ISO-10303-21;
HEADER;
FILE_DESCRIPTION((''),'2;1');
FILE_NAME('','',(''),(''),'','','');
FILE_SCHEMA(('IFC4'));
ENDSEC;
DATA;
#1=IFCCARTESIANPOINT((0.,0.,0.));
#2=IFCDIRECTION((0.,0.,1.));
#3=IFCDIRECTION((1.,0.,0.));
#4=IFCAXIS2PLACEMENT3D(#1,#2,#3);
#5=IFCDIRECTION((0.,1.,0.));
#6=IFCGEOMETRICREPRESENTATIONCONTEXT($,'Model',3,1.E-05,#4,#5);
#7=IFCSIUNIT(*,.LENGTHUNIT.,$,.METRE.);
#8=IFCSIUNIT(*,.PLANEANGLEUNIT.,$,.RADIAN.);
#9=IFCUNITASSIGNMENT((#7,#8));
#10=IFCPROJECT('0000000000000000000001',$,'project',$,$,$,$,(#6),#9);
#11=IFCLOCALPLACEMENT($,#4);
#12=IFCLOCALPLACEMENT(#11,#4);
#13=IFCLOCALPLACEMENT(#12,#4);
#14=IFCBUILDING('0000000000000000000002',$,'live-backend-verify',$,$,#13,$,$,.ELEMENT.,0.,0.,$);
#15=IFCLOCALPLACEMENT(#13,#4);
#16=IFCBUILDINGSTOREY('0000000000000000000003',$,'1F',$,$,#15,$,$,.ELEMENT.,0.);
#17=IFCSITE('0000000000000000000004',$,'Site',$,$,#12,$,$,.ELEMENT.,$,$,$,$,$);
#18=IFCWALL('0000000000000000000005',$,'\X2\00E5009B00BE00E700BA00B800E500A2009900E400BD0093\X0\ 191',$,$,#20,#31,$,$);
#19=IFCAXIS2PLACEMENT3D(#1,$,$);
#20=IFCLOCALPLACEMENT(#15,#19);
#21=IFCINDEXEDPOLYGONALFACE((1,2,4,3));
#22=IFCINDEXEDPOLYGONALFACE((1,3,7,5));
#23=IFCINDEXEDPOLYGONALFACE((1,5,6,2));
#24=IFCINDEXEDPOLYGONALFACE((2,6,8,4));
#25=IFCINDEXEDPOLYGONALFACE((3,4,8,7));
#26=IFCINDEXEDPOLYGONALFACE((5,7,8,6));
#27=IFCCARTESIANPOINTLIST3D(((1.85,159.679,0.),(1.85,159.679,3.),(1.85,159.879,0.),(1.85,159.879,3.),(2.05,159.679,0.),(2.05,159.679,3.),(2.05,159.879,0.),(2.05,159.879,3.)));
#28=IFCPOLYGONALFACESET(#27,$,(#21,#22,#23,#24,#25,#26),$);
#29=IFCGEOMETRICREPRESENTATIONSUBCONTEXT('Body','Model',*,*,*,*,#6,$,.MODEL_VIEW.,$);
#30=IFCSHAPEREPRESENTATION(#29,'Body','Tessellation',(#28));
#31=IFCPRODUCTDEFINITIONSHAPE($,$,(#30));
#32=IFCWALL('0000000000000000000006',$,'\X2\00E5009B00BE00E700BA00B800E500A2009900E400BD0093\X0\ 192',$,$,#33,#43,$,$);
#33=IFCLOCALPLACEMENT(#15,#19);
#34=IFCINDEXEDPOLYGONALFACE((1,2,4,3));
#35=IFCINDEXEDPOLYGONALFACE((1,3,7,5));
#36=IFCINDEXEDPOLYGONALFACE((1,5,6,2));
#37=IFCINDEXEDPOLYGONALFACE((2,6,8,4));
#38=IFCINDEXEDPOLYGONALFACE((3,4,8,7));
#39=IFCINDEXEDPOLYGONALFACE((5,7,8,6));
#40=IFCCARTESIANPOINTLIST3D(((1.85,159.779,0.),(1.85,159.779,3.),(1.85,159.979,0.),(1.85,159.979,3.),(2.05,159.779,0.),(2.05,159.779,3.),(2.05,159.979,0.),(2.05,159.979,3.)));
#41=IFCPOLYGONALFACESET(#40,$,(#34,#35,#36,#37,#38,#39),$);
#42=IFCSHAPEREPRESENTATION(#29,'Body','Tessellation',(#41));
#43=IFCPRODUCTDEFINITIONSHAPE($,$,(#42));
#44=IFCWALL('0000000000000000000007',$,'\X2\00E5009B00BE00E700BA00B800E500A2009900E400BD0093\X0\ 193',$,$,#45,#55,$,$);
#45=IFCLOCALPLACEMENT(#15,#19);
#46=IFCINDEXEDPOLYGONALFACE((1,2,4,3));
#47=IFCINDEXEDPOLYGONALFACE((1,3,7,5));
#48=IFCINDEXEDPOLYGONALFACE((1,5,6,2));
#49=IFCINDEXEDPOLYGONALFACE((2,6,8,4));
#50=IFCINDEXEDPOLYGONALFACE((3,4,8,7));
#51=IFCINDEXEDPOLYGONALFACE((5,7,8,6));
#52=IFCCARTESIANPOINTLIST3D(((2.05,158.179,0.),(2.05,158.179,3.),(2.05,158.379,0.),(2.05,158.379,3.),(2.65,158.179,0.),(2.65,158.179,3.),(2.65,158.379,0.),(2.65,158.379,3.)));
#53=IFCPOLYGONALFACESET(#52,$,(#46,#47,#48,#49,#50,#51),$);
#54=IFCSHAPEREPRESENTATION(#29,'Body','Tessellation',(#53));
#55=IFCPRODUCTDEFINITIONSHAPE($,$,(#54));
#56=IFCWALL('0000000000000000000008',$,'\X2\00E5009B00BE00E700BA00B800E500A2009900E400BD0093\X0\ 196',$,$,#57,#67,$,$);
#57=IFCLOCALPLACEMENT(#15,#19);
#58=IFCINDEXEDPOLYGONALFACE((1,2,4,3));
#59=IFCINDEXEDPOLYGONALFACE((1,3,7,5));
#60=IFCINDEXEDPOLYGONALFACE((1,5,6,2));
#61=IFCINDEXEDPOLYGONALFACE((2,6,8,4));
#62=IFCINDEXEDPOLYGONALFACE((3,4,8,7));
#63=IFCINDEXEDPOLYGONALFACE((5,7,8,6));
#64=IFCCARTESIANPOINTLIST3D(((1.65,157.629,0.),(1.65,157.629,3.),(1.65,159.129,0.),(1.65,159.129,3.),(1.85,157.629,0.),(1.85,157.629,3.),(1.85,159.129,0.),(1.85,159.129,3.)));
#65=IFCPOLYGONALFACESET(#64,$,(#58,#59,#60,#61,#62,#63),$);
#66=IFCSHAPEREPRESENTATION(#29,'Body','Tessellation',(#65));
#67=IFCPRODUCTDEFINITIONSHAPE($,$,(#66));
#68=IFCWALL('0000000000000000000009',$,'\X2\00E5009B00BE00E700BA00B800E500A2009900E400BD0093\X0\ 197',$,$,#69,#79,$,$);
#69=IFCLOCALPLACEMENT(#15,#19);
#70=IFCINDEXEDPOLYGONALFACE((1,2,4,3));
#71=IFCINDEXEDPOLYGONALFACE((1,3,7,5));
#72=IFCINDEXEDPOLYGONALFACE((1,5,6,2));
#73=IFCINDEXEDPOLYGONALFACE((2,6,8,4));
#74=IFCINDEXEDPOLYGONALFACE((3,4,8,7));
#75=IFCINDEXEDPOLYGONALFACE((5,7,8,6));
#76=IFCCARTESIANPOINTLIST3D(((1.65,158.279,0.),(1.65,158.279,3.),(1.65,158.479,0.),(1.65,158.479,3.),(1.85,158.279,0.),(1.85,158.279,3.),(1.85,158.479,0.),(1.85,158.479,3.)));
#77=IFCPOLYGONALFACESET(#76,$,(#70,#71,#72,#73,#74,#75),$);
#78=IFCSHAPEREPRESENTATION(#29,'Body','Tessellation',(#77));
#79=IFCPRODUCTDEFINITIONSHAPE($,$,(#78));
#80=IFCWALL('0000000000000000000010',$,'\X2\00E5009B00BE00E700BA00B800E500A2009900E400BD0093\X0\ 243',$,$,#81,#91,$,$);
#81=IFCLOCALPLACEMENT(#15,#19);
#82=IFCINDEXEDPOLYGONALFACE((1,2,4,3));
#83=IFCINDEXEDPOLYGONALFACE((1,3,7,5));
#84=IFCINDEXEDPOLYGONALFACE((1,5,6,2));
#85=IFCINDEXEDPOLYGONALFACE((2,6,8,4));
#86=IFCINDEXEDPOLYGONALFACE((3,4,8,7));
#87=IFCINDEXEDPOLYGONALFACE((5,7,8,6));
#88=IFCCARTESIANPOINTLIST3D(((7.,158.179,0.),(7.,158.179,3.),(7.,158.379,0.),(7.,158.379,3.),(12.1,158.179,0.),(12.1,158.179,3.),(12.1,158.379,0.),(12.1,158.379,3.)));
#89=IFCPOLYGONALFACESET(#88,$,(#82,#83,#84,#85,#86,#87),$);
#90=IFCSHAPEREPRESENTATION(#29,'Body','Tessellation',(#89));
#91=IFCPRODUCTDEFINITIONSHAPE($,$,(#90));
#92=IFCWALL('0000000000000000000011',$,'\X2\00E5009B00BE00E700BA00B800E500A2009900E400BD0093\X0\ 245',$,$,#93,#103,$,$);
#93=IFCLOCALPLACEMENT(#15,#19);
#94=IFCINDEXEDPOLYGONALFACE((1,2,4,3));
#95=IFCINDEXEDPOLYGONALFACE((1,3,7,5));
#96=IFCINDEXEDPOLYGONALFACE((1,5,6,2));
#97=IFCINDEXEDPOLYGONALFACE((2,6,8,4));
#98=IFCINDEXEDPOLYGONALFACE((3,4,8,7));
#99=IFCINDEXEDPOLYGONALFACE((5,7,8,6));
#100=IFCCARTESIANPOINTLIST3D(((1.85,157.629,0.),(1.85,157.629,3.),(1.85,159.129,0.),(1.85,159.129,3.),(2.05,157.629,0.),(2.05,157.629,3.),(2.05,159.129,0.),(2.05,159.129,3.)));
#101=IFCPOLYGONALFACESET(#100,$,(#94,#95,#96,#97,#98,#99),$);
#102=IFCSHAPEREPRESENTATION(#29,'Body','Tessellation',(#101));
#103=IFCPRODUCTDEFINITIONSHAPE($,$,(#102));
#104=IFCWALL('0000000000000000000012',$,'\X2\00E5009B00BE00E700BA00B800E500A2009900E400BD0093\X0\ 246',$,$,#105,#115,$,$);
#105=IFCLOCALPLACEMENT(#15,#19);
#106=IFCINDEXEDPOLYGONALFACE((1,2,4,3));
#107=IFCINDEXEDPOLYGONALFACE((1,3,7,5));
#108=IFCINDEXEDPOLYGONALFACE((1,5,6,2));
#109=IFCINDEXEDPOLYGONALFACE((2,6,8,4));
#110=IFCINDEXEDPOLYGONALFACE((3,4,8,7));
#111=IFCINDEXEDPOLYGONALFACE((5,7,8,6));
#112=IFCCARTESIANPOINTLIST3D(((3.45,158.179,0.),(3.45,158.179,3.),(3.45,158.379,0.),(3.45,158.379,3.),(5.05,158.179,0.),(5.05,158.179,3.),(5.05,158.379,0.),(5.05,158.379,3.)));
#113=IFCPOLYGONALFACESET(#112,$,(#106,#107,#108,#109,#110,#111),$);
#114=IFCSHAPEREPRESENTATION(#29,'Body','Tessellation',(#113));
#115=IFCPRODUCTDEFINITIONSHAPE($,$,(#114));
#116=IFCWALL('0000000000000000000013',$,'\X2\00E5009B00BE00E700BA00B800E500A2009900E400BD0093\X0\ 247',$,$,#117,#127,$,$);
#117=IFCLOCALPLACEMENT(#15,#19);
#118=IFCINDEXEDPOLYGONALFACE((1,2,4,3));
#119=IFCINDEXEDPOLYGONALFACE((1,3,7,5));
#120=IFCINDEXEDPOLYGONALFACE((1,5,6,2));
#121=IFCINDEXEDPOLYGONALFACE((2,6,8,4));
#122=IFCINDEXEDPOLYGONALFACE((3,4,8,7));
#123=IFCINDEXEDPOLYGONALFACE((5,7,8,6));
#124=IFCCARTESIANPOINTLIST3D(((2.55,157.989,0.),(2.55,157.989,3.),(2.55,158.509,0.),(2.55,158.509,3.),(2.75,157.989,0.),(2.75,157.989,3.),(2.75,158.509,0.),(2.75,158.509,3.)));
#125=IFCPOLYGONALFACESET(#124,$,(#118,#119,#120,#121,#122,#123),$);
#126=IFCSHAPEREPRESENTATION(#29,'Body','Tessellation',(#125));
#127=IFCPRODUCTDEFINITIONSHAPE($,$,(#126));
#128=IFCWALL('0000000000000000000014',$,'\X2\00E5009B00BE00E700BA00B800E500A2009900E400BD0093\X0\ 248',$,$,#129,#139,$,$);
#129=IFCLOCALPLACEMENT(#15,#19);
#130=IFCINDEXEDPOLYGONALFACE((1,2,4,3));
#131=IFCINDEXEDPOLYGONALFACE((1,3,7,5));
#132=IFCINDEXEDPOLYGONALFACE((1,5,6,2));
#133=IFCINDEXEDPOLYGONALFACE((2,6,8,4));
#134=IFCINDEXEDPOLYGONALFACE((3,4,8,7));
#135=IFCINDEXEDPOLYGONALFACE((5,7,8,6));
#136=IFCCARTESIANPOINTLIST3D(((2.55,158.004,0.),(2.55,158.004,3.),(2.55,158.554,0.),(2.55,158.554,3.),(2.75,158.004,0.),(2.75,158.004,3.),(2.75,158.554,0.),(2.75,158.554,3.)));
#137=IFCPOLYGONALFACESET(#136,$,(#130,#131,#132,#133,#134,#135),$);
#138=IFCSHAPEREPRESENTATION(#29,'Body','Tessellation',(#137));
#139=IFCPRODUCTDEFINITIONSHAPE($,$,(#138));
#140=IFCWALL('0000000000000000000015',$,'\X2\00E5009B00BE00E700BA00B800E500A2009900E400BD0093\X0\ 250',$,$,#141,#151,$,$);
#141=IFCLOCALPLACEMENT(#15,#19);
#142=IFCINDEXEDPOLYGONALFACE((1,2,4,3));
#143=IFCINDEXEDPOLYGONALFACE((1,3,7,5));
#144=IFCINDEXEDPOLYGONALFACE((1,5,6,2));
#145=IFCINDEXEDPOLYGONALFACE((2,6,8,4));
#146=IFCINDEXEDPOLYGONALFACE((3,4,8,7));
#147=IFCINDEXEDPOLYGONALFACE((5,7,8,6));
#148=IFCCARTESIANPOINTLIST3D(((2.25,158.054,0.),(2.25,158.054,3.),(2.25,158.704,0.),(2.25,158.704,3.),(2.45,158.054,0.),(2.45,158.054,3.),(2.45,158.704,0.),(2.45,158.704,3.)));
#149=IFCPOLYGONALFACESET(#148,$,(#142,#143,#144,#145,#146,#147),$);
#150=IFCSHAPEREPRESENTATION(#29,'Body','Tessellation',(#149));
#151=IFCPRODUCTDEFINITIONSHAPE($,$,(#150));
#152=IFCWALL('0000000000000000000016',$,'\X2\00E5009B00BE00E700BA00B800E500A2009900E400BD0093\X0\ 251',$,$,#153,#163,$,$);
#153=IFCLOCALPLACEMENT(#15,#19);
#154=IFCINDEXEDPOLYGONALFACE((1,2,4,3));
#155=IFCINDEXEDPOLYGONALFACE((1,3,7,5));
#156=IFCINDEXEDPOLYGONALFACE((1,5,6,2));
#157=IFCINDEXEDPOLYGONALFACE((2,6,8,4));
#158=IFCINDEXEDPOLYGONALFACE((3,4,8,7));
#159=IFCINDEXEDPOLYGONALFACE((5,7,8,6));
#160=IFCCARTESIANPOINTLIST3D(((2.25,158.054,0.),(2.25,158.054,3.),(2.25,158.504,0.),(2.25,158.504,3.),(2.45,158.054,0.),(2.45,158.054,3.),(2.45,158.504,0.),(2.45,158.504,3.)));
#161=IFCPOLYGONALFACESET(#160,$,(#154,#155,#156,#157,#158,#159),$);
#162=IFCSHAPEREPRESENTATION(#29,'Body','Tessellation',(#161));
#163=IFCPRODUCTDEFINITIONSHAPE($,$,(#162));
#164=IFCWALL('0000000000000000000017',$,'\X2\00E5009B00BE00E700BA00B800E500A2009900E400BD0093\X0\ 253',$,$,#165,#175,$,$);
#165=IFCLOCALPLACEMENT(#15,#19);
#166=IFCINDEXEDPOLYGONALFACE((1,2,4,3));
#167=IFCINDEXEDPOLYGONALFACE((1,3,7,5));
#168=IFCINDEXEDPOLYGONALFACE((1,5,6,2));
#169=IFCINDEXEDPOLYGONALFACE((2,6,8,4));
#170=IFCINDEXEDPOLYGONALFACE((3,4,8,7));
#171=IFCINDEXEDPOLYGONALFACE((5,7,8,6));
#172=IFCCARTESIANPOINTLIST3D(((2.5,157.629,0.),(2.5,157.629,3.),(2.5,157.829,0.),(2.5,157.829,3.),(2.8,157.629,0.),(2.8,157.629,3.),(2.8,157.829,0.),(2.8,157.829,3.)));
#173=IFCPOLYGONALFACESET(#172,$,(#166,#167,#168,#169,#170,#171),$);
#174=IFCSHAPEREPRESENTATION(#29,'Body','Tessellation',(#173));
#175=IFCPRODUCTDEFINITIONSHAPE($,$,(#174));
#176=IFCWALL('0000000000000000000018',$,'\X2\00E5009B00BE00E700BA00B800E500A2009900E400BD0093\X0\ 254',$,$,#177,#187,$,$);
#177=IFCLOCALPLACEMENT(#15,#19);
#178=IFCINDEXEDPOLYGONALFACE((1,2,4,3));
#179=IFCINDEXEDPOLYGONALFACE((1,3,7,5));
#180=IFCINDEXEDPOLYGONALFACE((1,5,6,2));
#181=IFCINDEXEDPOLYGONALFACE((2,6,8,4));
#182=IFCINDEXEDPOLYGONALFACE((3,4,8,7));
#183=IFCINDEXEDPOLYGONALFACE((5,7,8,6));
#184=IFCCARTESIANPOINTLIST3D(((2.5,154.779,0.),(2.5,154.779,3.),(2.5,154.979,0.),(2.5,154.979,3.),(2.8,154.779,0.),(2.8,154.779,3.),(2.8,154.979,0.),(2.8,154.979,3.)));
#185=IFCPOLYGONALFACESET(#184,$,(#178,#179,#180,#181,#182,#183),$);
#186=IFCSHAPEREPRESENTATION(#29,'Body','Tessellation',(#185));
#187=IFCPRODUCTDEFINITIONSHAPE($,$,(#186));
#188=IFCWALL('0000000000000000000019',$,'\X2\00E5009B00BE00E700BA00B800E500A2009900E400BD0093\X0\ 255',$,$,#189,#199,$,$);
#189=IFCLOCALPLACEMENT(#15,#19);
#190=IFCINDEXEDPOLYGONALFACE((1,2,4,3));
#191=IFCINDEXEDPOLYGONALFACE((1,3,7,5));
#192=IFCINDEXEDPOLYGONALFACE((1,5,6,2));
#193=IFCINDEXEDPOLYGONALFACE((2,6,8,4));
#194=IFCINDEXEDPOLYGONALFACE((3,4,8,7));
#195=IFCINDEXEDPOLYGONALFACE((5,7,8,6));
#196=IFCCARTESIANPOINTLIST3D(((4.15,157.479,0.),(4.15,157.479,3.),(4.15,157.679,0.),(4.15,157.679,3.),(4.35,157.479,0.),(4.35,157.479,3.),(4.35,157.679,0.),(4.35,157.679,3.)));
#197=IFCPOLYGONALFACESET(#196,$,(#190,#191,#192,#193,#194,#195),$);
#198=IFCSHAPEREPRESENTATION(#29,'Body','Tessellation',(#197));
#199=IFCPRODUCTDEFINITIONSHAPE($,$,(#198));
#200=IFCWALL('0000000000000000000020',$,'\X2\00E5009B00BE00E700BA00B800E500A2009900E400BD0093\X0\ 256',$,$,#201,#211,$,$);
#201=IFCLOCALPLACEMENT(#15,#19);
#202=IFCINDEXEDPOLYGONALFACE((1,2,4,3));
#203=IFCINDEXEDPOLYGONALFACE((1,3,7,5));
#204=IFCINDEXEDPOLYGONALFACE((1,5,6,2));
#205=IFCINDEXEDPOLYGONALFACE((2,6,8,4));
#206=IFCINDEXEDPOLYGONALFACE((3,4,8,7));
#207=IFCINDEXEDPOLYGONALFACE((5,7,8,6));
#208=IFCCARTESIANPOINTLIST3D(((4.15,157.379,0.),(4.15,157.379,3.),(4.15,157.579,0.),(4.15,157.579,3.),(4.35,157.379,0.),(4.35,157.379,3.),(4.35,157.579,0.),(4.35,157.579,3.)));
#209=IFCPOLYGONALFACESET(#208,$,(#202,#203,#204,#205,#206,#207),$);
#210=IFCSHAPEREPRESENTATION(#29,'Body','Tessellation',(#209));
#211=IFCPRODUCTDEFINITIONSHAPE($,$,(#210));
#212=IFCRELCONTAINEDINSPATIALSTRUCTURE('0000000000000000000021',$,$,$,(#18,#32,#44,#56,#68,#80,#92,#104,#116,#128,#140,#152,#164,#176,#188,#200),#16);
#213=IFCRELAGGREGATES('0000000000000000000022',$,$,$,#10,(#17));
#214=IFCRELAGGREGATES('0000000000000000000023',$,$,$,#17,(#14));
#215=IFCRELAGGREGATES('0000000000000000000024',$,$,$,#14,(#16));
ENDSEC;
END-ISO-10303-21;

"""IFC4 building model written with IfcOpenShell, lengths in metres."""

from ifc_helpers import new_model, si_unit, direction, frame, frame_2d, origin_with_axes, place, context, subcontext, project, spatial, rectangle, extrude, element, save


model = new_model("IFC4")

# Units and contexts
model_context = context("Model", 3, precision=1e-05, world=origin_with_axes(), true_north=direction((0.0, 1.0, 0.0)))
body_context = subcontext(model_context, "Body", "Model", "MODEL_VIEW")
ifc_project = project(units=[si_unit("LENGTHUNIT", "METRE"), si_unit("PLANEANGLEUNIT", "RADIAN")], contexts=[model_context])

# Site, building, storey
placement = place(None, origin_with_axes())
site_placement = place(placement, origin_with_axes())
site = spatial("IfcSite", under=ifc_project, at=site_placement, Name="Site", CompositionType="ELEMENT")
building_placement = place(site_placement, origin_with_axes())
building = spatial("IfcBuilding", under=site, at=building_placement, Name="live-backend-verify", CompositionType="ELEMENT", ElevationOfRefHeight=0.0, ElevationOfTerrain=0.0)
storey_placement = place(building_placement, origin_with_axes())
storey = spatial("IfcBuildingStorey", under=building, at=storey_placement, Name="1F", CompositionType="ELEMENT", Elevation=0.0)

# Walls
for number, where, z_axis, x_axis, name in (
    (1, (1.95, 159.779, 0.0), (0.0, 0.0, 1.0), (-1.0, 0.0, 0.0), "å\u009b¾çº¸å¢\u0099ä½\u0093 191"),
    (2, (1.95, 159.879, 0.0), (0.0, 0.0, 1.0), (-1.0, 0.0, 0.0), "å\u009b¾çº¸å¢\u0099ä½\u0093 192"),
):
    element("IfcWall", number, at=place(storey_placement, frame(where, z_axis=z_axis, x_axis=x_axis)), inside=storey, Name=name, context=body_context, shape_type="SweptSolid", body=[
        extrude(rectangle(XDim=0.2, YDim=0.2, at=frame_2d((0.0, 0.0), x_axis=(1.0, 0.0, 0.0))), frame((0.0, 0.0, 0.0), z_axis=(0.0, 0.0, 1.0)), (0.0, 0.0, 1.0), 3.0),
    ])
wall_1_placement = place(storey_placement, frame((2.35, 158.279, 0.0), z_axis=(0.0, 0.0, 1.0), x_axis=(-1.0, 0.0, 0.0)))
element("IfcWall", 3, at=wall_1_placement, inside=storey, Name="å\u009b¾çº¸å¢\u0099ä½\u0093 193", context=body_context, shape_type="SweptSolid", body=[
    extrude(rectangle(XDim=0.6, YDim=0.2, at=frame_2d((0.0, 0.0), x_axis=(1.0, 0.0, 0.0))), frame((0.0, 0.0, 0.0), z_axis=(0.0, 0.0, 1.0)), (0.0, 0.0, 1.0), 3.0),
])
wall_2_placement = place(storey_placement, frame((1.75, 158.379, 0.0), z_axis=(0.0, 0.0, 1.0), x_axis=(0.0, 1.0, 0.0)))
element("IfcWall", 4, at=wall_2_placement, inside=storey, Name="å\u009b¾çº¸å¢\u0099ä½\u0093 196", context=body_context, shape_type="SweptSolid", body=[
    extrude(rectangle(XDim=1.5, YDim=0.2, at=frame_2d((0.0, 0.0), x_axis=(1.0, 0.0, 0.0))), frame((0.0, 0.0, 0.0), z_axis=(0.0, 0.0, 1.0)), (0.0, 0.0, 1.0), 3.0),
])
wall_3_placement = place(storey_placement, frame((1.75, 158.379, 0.0), z_axis=(0.0, 0.0, 1.0), x_axis=(0.0, -1.0, 0.0)))
element("IfcWall", 5, at=wall_3_placement, inside=storey, Name="å\u009b¾çº¸å¢\u0099ä½\u0093 197", context=body_context, shape_type="SweptSolid", body=[
    extrude(rectangle(XDim=0.2, YDim=0.2, at=frame_2d((0.0, 0.0), x_axis=(1.0, 0.0, 0.0))), frame((0.0, 0.0, 0.0), z_axis=(0.0, 0.0, 1.0)), (0.0, 0.0, 1.0), 3.0),
])
wall_4_placement = place(storey_placement, frame((9.55, 158.279, 0.0), z_axis=(0.0, 0.0, 1.0), x_axis=(-1.0, 0.0, 0.0)))
element("IfcWall", 6, at=wall_4_placement, inside=storey, Name="å\u009b¾çº¸å¢\u0099ä½\u0093 243", context=body_context, shape_type="SweptSolid", body=[
    extrude(rectangle(XDim=5.1, YDim=0.2, at=frame_2d((0.0, 0.0), x_axis=(1.0, 0.0, 0.0))), frame((0.0, 0.0, 0.0), z_axis=(0.0, 0.0, 1.0)), (0.0, 0.0, 1.0), 3.0),
])
wall_5_placement = place(storey_placement, frame((1.95, 158.379, 0.0), z_axis=(0.0, 0.0, 1.0), x_axis=(0.0, 1.0, 0.0)))
element("IfcWall", 7, at=wall_5_placement, inside=storey, Name="å\u009b¾çº¸å¢\u0099ä½\u0093 245", context=body_context, shape_type="SweptSolid", body=[
    extrude(rectangle(XDim=1.5, YDim=0.2, at=frame_2d((0.0, 0.0), x_axis=(1.0, 0.0, 0.0))), frame((0.0, 0.0, 0.0), z_axis=(0.0, 0.0, 1.0)), (0.0, 0.0, 1.0), 3.0),
])
wall_6_placement = place(storey_placement, frame((4.25, 158.279, 0.0), z_axis=(0.0, 0.0, 1.0), x_axis=(-1.0, 0.0, 0.0)))
element("IfcWall", 8, at=wall_6_placement, inside=storey, Name="å\u009b¾çº¸å¢\u0099ä½\u0093 246", context=body_context, shape_type="SweptSolid", body=[
    extrude(rectangle(XDim=1.6, YDim=0.2, at=frame_2d((0.0, 0.0), x_axis=(1.0, 0.0, 0.0))), frame((0.0, 0.0, 0.0), z_axis=(0.0, 0.0, 1.0)), (0.0, 0.0, 1.0), 3.0),
])
wall_7_placement = place(storey_placement, frame((2.65, 158.249, 0.0), z_axis=(0.0, 0.0, 1.0), x_axis=(0.0, -1.0, 0.0)))
element("IfcWall", 9, at=wall_7_placement, inside=storey, Name="å\u009b¾çº¸å¢\u0099ä½\u0093 247", context=body_context, shape_type="SweptSolid", body=[
    extrude(rectangle(XDim=0.52, YDim=0.2, at=frame_2d((0.0, 0.0), x_axis=(1.0, 0.0, 0.0))), frame((0.0, 0.0, 0.0), z_axis=(0.0, 0.0, 1.0)), (0.0, 0.0, 1.0), 3.0),
])
wall_8_placement = place(storey_placement, frame((2.65, 158.279, 0.0), z_axis=(0.0, 0.0, 1.0), x_axis=(0.0, -1.0, 0.0)))
element("IfcWall", 10, at=wall_8_placement, inside=storey, Name="å\u009b¾çº¸å¢\u0099ä½\u0093 248", context=body_context, shape_type="SweptSolid", body=[
    extrude(rectangle(XDim=0.55, YDim=0.2, at=frame_2d((0.0, 0.0), x_axis=(1.0, 0.0, 0.0))), frame((0.0, 0.0, 0.0), z_axis=(0.0, 0.0, 1.0)), (0.0, 0.0, 1.0), 3.0),
])
wall_9_placement = place(storey_placement, frame((2.35, 158.379, 0.0), z_axis=(0.0, 0.0, 1.0), x_axis=(0.0, -1.0, 0.0)))
element("IfcWall", 11, at=wall_9_placement, inside=storey, Name="å\u009b¾çº¸å¢\u0099ä½\u0093 250", context=body_context, shape_type="SweptSolid", body=[
    extrude(rectangle(XDim=0.65, YDim=0.2, at=frame_2d((0.0, 0.0), x_axis=(1.0, 0.0, 0.0))), frame((0.0, 0.0, 0.0), z_axis=(0.0, 0.0, 1.0)), (0.0, 0.0, 1.0), 3.0),
])
wall_10_placement = place(storey_placement, frame((2.35, 158.279, 0.0), z_axis=(0.0, 0.0, 1.0), x_axis=(0.0, -1.0, 0.0)))
element("IfcWall", 12, at=wall_10_placement, inside=storey, Name="å\u009b¾çº¸å¢\u0099ä½\u0093 251", context=body_context, shape_type="SweptSolid", body=[
    extrude(rectangle(XDim=0.45, YDim=0.2, at=frame_2d((0.0, 0.0), x_axis=(1.0, 0.0, 0.0))), frame((0.0, 0.0, 0.0), z_axis=(0.0, 0.0, 1.0)), (0.0, 0.0, 1.0), 3.0),
])
for number, where, z_axis, x_axis, name in (
    (13, (2.65, 157.729, 0.0), (0.0, 0.0, 1.0), (-1.0, 0.0, 0.0), "å\u009b¾çº¸å¢\u0099ä½\u0093 253"),
    (14, (2.65, 154.879, 0.0), (0.0, 0.0, 1.0), (-1.0, 0.0, 0.0), "å\u009b¾çº¸å¢\u0099ä½\u0093 254"),
):
    element("IfcWall", number, at=place(storey_placement, frame(where, z_axis=z_axis, x_axis=x_axis)), inside=storey, Name=name, context=body_context, shape_type="SweptSolid", body=[
        extrude(rectangle(XDim=0.3, YDim=0.2, at=frame_2d((0.0, 0.0), x_axis=(1.0, 0.0, 0.0))), frame((0.0, 0.0, 0.0), z_axis=(0.0, 0.0, 1.0)), (0.0, 0.0, 1.0), 3.0),
    ])
for number, where, z_axis, x_axis, name in (
    (15, (4.25, 157.579, 0.0), (0.0, 0.0, 1.0), (1.0, 0.0, 0.0), "å\u009b¾çº¸å¢\u0099ä½\u0093 255"),
    (16, (4.25, 157.479, 0.0), (0.0, 0.0, 1.0), (1.0, 0.0, 0.0), "å\u009b¾çº¸å¢\u0099ä½\u0093 256"),
):
    element("IfcWall", number, at=place(storey_placement, frame(where, z_axis=z_axis, x_axis=x_axis)), inside=storey, Name=name, context=body_context, shape_type="SweptSolid", body=[
        extrude(rectangle(XDim=0.2, YDim=0.2, at=frame_2d((0.0, 0.0), x_axis=(1.0, 0.0, 0.0))), frame((0.0, 0.0, 0.0), z_axis=(0.0, 0.0, 1.0)), (0.0, 0.0, 1.0), 3.0),
    ])

save(model, "model.ifc")
